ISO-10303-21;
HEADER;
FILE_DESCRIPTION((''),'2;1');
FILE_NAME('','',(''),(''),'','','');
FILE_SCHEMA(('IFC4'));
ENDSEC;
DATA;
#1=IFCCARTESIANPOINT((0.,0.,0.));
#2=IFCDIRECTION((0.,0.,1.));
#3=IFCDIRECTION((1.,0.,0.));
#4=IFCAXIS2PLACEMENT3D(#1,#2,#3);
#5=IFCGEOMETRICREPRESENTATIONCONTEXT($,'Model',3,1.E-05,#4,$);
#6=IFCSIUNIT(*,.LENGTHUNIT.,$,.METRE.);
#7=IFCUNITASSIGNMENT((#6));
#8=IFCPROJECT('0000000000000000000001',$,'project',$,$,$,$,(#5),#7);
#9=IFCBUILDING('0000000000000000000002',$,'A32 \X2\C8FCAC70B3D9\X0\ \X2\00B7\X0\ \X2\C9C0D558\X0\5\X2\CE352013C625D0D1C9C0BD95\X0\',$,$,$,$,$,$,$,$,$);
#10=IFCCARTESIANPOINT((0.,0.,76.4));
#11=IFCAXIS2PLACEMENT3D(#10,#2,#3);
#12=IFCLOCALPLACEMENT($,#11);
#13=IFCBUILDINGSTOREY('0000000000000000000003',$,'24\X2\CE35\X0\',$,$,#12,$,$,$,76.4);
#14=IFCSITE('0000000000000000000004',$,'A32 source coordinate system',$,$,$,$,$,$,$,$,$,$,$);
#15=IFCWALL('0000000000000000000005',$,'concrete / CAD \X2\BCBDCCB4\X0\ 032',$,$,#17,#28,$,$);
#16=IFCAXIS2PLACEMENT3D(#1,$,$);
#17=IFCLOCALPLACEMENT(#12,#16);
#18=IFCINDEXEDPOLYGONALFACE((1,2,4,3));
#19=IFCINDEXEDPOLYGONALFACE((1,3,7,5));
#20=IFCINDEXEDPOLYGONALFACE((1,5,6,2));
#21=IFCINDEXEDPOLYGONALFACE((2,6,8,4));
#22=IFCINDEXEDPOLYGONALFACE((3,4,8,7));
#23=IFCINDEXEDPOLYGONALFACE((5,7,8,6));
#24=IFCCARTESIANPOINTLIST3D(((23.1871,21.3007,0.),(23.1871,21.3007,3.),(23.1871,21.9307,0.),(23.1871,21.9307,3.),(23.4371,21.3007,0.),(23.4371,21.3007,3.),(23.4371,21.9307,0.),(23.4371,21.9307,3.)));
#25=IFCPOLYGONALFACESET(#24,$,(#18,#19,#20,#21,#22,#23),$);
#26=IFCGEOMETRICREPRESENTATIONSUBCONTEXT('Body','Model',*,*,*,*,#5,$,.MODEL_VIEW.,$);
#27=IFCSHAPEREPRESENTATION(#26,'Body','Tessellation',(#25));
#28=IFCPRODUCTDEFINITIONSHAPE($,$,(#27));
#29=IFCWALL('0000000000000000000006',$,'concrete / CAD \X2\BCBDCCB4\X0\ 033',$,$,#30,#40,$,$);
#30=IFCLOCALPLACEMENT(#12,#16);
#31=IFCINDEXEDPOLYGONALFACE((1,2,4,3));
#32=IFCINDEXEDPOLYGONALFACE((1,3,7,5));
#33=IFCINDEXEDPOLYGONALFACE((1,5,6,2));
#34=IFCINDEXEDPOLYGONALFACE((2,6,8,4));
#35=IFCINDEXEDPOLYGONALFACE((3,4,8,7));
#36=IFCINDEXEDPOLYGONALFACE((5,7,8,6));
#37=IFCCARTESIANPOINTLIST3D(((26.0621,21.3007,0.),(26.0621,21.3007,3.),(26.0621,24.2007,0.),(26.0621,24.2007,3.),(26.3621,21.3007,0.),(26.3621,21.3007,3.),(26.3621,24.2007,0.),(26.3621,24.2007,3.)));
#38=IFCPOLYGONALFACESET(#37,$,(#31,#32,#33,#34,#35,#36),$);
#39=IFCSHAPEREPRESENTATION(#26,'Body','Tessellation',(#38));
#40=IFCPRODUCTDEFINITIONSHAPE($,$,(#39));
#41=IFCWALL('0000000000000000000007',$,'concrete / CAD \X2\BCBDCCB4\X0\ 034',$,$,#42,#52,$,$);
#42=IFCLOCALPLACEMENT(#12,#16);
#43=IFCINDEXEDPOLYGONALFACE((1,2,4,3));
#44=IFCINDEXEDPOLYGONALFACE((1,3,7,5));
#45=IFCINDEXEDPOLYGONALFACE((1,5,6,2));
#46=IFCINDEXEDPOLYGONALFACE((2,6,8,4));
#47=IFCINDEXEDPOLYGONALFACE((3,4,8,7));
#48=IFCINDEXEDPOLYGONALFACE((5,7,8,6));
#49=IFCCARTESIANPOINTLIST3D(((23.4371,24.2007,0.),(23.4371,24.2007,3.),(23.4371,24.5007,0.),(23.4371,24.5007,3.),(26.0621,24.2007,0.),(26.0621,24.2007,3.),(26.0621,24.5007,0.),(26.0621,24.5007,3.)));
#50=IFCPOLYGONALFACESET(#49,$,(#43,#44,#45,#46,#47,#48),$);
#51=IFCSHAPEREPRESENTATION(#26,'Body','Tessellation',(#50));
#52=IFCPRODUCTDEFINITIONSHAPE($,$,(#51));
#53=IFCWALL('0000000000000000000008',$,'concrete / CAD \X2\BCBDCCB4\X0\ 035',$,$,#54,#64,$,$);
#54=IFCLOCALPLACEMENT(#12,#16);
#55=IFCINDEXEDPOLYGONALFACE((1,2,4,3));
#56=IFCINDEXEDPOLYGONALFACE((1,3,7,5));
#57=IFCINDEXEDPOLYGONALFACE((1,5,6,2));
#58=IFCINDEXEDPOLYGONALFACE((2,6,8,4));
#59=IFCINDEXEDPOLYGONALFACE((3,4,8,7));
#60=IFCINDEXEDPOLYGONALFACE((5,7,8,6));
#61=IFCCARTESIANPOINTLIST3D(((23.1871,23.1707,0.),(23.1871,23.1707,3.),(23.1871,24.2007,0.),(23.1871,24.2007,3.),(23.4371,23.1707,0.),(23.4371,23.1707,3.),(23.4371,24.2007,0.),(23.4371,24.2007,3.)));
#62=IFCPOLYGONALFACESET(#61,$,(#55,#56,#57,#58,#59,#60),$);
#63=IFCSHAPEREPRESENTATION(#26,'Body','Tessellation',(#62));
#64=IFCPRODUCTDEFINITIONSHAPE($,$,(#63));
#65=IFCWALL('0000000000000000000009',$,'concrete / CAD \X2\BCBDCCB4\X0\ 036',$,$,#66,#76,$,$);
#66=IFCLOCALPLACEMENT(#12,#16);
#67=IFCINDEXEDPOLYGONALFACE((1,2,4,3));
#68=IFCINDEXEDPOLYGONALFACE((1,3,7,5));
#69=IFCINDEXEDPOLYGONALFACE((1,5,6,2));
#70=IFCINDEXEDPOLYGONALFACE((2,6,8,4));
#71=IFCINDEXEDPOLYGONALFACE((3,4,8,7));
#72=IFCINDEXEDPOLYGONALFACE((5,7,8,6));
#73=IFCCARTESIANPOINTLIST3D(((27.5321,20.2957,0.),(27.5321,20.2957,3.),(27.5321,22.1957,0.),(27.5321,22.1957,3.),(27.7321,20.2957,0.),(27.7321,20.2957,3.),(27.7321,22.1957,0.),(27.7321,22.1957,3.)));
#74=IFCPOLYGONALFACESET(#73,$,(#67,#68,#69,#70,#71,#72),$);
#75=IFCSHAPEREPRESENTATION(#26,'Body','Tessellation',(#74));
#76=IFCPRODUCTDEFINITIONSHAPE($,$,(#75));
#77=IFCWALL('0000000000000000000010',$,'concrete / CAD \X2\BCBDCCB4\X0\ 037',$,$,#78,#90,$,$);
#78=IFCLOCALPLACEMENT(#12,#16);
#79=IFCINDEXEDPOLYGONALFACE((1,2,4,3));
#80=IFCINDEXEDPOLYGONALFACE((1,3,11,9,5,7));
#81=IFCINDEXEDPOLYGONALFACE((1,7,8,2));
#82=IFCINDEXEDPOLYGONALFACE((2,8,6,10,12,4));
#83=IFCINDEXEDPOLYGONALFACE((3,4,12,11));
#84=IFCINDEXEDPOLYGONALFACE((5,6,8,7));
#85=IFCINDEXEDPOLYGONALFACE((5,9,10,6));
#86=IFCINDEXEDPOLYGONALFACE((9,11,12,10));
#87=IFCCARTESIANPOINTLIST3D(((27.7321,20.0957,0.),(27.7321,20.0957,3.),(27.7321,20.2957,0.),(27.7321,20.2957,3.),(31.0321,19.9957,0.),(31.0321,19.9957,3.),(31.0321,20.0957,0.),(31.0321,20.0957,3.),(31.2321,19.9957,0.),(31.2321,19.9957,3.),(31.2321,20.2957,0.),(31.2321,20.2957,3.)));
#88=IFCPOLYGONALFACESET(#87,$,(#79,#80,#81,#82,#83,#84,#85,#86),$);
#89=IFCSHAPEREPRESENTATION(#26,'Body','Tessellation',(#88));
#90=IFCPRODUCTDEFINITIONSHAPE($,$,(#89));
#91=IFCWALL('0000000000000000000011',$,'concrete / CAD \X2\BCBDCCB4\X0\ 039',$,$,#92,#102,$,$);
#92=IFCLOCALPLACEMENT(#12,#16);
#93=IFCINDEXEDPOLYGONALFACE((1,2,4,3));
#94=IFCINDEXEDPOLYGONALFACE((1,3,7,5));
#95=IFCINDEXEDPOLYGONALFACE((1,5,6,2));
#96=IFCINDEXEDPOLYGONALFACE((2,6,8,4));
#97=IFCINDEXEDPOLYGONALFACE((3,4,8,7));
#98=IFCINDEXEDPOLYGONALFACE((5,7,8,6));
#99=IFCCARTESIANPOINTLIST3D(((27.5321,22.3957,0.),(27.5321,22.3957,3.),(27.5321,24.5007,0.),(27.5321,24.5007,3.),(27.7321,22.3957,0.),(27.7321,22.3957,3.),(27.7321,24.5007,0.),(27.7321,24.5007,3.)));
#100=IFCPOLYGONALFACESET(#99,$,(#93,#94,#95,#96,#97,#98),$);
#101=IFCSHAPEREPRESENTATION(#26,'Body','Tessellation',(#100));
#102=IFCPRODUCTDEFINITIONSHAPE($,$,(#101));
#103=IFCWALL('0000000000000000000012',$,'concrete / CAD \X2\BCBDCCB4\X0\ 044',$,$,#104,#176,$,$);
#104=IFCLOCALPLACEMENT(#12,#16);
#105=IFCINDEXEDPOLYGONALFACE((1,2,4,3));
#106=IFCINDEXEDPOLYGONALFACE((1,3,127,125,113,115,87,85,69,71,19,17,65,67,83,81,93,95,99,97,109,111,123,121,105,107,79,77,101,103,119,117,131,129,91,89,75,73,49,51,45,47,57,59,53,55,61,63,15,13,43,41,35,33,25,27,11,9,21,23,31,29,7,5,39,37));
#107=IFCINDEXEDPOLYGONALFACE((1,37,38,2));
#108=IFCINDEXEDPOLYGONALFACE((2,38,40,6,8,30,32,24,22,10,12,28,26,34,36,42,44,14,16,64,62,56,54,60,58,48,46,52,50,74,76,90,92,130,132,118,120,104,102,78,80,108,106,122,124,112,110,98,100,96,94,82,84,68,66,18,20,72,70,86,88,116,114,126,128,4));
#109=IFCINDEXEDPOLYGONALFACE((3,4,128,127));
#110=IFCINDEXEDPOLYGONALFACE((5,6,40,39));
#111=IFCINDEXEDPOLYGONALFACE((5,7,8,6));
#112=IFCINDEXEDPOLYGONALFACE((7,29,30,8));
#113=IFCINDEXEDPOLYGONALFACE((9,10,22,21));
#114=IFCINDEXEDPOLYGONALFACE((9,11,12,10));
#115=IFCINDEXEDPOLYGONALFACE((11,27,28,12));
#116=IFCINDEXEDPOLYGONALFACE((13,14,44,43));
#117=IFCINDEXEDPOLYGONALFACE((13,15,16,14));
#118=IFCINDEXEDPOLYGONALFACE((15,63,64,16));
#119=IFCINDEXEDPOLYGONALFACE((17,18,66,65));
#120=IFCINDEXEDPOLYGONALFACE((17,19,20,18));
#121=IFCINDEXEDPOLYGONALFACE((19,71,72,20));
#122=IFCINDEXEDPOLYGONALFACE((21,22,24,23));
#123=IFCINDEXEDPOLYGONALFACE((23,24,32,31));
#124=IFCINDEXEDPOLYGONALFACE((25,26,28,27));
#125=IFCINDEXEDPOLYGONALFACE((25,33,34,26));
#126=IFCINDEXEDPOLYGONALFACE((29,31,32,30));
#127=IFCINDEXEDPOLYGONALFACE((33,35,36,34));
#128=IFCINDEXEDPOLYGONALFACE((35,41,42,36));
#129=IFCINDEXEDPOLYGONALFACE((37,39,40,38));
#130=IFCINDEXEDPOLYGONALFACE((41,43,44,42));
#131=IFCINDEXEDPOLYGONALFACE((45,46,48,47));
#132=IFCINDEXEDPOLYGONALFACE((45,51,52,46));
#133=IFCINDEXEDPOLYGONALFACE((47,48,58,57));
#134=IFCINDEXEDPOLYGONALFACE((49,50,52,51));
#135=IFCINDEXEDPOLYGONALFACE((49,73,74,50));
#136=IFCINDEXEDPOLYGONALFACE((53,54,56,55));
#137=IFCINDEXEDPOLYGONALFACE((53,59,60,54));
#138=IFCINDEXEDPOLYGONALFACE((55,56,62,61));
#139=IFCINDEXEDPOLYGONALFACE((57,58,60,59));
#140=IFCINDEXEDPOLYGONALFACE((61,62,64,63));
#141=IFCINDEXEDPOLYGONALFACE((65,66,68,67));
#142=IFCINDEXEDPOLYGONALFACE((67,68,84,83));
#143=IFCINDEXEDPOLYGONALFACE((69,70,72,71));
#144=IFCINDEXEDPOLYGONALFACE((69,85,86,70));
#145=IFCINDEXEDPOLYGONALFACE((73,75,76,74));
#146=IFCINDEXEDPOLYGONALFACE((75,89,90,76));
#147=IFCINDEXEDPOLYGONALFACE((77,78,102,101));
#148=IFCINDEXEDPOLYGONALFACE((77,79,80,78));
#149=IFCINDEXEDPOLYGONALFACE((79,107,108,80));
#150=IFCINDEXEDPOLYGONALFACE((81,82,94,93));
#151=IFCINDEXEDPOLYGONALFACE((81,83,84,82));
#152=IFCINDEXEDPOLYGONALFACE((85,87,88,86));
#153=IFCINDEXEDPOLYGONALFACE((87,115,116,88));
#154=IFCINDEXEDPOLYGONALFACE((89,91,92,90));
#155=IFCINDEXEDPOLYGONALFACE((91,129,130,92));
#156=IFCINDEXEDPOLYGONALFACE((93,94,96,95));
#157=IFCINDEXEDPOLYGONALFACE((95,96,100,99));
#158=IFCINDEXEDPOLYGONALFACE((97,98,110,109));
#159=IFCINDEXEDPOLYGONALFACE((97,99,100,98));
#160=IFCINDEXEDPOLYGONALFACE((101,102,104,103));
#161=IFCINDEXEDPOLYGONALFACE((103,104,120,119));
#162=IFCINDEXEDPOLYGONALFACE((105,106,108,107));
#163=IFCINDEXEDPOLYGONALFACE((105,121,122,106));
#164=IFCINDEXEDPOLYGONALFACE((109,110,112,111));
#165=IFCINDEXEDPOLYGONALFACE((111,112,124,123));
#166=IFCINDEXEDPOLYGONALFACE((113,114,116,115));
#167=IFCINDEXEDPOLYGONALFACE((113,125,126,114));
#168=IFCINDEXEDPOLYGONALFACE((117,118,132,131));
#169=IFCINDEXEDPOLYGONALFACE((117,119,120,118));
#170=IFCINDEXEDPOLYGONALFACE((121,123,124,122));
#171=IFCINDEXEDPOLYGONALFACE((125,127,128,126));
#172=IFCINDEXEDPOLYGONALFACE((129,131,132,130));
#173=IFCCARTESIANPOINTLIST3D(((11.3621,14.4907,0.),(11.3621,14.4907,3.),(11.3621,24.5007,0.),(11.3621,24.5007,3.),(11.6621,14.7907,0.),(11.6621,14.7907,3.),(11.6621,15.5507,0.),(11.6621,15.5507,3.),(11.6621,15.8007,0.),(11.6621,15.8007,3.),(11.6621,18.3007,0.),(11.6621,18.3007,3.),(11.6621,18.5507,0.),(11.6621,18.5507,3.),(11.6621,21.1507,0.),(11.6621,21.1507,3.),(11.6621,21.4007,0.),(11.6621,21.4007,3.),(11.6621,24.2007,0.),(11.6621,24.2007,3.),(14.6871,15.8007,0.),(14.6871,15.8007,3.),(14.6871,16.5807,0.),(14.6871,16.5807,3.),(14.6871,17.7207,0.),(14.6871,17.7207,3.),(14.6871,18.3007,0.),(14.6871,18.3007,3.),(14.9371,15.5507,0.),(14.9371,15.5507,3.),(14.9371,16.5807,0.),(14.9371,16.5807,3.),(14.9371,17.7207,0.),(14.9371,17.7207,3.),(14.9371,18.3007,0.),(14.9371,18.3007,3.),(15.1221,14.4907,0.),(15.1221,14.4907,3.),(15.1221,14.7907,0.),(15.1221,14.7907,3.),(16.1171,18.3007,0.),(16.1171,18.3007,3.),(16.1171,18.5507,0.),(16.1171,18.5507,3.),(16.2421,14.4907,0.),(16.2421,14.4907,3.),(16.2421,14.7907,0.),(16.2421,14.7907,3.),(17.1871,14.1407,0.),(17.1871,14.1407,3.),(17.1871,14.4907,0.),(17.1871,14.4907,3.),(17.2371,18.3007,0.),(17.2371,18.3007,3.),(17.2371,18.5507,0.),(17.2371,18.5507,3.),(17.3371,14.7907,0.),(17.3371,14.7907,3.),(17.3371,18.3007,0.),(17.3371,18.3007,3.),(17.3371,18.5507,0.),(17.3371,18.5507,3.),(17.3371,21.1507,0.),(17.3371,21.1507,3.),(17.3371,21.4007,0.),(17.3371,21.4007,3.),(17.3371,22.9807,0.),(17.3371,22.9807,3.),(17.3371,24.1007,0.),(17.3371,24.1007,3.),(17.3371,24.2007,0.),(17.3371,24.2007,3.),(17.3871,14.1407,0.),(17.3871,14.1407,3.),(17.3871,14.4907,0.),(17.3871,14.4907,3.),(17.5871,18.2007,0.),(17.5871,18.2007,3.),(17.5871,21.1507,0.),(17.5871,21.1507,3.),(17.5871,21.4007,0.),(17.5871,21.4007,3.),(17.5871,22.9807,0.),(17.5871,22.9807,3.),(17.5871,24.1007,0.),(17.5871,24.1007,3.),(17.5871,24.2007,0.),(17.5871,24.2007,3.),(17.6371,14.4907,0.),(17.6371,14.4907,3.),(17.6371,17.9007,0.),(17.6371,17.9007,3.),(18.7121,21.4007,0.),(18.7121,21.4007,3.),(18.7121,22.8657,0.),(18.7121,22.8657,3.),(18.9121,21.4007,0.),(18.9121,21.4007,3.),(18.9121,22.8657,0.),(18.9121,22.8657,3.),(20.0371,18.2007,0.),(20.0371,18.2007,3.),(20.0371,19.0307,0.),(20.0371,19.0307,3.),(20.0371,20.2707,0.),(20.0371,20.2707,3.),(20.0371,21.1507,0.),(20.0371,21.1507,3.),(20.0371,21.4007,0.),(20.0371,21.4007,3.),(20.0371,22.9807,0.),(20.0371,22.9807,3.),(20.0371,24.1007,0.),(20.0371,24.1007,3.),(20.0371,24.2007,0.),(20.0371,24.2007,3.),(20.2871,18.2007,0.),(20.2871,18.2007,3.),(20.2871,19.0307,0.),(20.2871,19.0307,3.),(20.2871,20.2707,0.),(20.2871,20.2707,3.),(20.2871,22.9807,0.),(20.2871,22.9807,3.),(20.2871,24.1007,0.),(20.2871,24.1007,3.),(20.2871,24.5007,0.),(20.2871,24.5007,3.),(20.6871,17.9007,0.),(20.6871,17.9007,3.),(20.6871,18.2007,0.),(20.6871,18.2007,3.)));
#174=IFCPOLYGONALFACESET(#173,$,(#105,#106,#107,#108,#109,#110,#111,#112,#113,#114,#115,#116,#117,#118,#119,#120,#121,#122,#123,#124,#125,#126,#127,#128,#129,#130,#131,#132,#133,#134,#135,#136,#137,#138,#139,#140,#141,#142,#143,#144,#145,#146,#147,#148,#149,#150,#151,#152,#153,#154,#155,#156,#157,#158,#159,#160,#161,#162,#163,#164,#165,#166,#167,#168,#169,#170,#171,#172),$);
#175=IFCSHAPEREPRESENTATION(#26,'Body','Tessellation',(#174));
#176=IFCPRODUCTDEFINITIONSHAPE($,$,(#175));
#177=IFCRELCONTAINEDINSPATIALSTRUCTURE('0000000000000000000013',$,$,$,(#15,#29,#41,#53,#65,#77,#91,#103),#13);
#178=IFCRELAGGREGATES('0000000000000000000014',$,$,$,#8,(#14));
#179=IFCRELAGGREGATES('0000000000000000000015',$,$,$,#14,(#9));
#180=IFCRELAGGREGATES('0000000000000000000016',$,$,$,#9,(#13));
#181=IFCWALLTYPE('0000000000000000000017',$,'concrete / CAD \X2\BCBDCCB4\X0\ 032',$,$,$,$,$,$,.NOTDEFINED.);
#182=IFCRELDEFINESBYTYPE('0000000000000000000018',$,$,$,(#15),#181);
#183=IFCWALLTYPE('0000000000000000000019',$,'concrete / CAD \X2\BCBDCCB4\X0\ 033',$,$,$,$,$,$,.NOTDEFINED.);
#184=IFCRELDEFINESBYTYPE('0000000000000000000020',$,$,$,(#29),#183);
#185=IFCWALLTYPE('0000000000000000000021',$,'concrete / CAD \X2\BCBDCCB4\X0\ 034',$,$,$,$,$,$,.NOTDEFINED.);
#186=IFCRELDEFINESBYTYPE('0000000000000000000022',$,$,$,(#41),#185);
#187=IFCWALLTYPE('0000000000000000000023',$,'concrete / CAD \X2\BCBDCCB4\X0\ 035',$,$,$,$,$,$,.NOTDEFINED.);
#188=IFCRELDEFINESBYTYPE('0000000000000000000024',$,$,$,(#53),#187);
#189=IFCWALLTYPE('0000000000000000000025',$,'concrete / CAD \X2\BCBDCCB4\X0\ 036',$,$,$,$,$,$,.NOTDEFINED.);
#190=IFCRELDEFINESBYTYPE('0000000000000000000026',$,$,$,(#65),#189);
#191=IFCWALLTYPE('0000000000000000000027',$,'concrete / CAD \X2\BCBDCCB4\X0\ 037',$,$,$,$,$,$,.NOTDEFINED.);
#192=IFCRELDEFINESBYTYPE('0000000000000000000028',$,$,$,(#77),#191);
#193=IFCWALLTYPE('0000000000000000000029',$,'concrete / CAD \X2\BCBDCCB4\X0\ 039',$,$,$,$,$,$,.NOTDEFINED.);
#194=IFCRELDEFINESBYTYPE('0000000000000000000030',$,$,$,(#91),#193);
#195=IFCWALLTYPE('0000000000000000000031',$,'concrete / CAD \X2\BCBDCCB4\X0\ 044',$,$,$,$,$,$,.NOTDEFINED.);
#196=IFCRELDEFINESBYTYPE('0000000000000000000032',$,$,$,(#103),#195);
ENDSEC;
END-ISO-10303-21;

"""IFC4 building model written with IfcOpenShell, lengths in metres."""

from ifc_helpers import new_model, si_unit, frame, origin, origin_with_axes, place, context, subcontext, project, spatial, polyline, outline, extrude, source, transform, mapped, type_object, type_shapes, element, save


model = new_model("IFC4")

# Units and contexts
model_context = context("Model", 3, precision=1e-05, world=origin_with_axes())
body_context = subcontext(model_context, "Body", "Model", "MODEL_VIEW")
ifc_project = project(units=[si_unit("LENGTHUNIT", "METRE")], contexts=[model_context])

# Site, building, storey
site = spatial("IfcSite", under=ifc_project, Name="A32 source coordinate system")
building = spatial("IfcBuilding", under=site, Name="A32 주거동 · 지하5층–옥탑지붕")
storey_placement = place(None, frame((0.0, 0.0, 76.4), z_axis=(0.0, 0.0, 1.0), x_axis=(1.0, 0.0, 0.0)))
storey = spatial("IfcBuildingStorey", under=building, at=storey_placement, Name="24층", Elevation=76.4)

# Walls
wall_type_1 = type_object("IfcWallType", Name="concrete / CAD 벽체 032", PredefinedType="NOTDEFINED")
shared_shape_1 = source(origin(), body_context, "Body", "SweptSolid", [
    extrude(outline(polyline([(23.4371, 21.3007), (23.1871, 21.3007), (23.1871, 21.9307), (23.4371, 21.9307), (23.4371, 21.3007)])), origin(), (0.0, 0.0, 1.0), 3.0),
])
type_shapes(wall_type_1, [shared_shape_1])
wall_1_placement = place(storey_placement, origin_with_axes())
element("IfcWall", 1, at=wall_1_placement, inside=storey, type_object=wall_type_1, Name="concrete / CAD 벽체 032", context=body_context, shape_type="MappedRepresentation", body=[
    mapped(shared_shape_1, transform((0.0, 0.0, 0.0), scale=1.0)),
])
wall_type_2 = type_object("IfcWallType", Name="concrete / CAD 벽체 033", PredefinedType="NOTDEFINED")
shared_shape_2 = source(origin(), body_context, "Body", "SweptSolid", [
    extrude(outline(polyline([(26.3621, 21.3007), (26.0621, 21.3007), (26.0621, 24.2007), (26.3621, 24.2007), (26.3621, 21.3007)])), origin(), (0.0, 0.0, 1.0), 3.0),
])
type_shapes(wall_type_2, [shared_shape_2])
wall_2_placement = place(storey_placement, origin_with_axes())
element("IfcWall", 2, at=wall_2_placement, inside=storey, type_object=wall_type_2, Name="concrete / CAD 벽체 033", context=body_context, shape_type="MappedRepresentation", body=[
    mapped(shared_shape_2, transform((0.0, 0.0, 0.0), scale=1.0)),
])
wall_type_3 = type_object("IfcWallType", Name="concrete / CAD 벽체 034", PredefinedType="NOTDEFINED")
shared_shape_3 = source(origin(), body_context, "Body", "SweptSolid", [
    extrude(outline(polyline([(26.0621, 24.5007), (26.0621, 24.2007), (23.4371, 24.2007), (23.4371, 24.5007), (26.0621, 24.5007)])), origin(), (0.0, 0.0, 1.0), 3.0),
])
type_shapes(wall_type_3, [shared_shape_3])
wall_3_placement = place(storey_placement, origin_with_axes())
element("IfcWall", 3, at=wall_3_placement, inside=storey, type_object=wall_type_3, Name="concrete / CAD 벽체 034", context=body_context, shape_type="MappedRepresentation", body=[
    mapped(shared_shape_3, transform((0.0, 0.0, 0.0), scale=1.0)),
])
wall_type_4 = type_object("IfcWallType", Name="concrete / CAD 벽체 035", PredefinedType="NOTDEFINED")
shared_shape_4 = source(origin(), body_context, "Body", "SweptSolid", [
    extrude(outline(polyline([(23.1871, 24.2007), (23.4371, 24.2007), (23.4371, 23.1707), (23.1871, 23.1707), (23.1871, 24.2007)])), origin(), (0.0, 0.0, 1.0), 3.0),
])
type_shapes(wall_type_4, [shared_shape_4])
wall_4_placement = place(storey_placement, origin_with_axes())
element("IfcWall", 4, at=wall_4_placement, inside=storey, type_object=wall_type_4, Name="concrete / CAD 벽체 035", context=body_context, shape_type="MappedRepresentation", body=[
    mapped(shared_shape_4, transform((0.0, 0.0, 0.0), scale=1.0)),
])
wall_type_5 = type_object("IfcWallType", Name="concrete / CAD 벽체 036", PredefinedType="NOTDEFINED")
shared_shape_5 = source(origin(), body_context, "Body", "SweptSolid", [
    extrude(outline(polyline([(27.7321, 20.2957), (27.5321, 20.2957), (27.5321, 22.1957), (27.7321, 22.1957), (27.7321, 20.2957)])), origin(), (0.0, 0.0, 1.0), 3.0),
])
type_shapes(wall_type_5, [shared_shape_5])
wall_5_placement = place(storey_placement, origin_with_axes())
element("IfcWall", 5, at=wall_5_placement, inside=storey, type_object=wall_type_5, Name="concrete / CAD 벽체 036", context=body_context, shape_type="MappedRepresentation", body=[
    mapped(shared_shape_5, transform((0.0, 0.0, 0.0), scale=1.0)),
])
wall_type_6 = type_object("IfcWallType", Name="concrete / CAD 벽체 037", PredefinedType="NOTDEFINED")
shared_shape_6 = source(origin(), body_context, "Body", "SweptSolid", [
    extrude(outline(polyline([(31.0321, 19.9957), (31.0321, 20.0957), (27.7321, 20.0957), (27.7321, 20.2957), (31.2321, 20.2957), (31.2321, 19.9957), (31.0321, 19.9957)])), origin(), (0.0, 0.0, 1.0), 3.0),
])
type_shapes(wall_type_6, [shared_shape_6])
wall_6_placement = place(storey_placement, origin_with_axes())
element("IfcWall", 6, at=wall_6_placement, inside=storey, type_object=wall_type_6, Name="concrete / CAD 벽체 037", context=body_context, shape_type="MappedRepresentation", body=[
    mapped(shared_shape_6, transform((0.0, 0.0, 0.0), scale=1.0)),
])
wall_type_7 = type_object("IfcWallType", Name="concrete / CAD 벽체 039", PredefinedType="NOTDEFINED")
shared_shape_7 = source(origin(), body_context, "Body", "SweptSolid", [
    extrude(outline(polyline([(27.7321, 22.3957), (27.5321, 22.3957), (27.5321, 24.5007), (27.7321, 24.5007), (27.7321, 22.3957)])), origin(), (0.0, 0.0, 1.0), 3.0),
])
type_shapes(wall_type_7, [shared_shape_7])
wall_7_placement = place(storey_placement, origin_with_axes())
element("IfcWall", 7, at=wall_7_placement, inside=storey, type_object=wall_type_7, Name="concrete / CAD 벽체 039", context=body_context, shape_type="MappedRepresentation", body=[
    mapped(shared_shape_7, transform((0.0, 0.0, 0.0), scale=1.0)),
])
wall_type_8 = type_object("IfcWallType", Name="concrete / CAD 벽체 044", PredefinedType="NOTDEFINED")
shared_shape_8 = source(origin(), body_context, "Body", "SweptSolid", [
    extrude(outline(polyline([(17.3371, 22.9807), (17.5871, 22.9807), (17.5871, 21.4007), (18.7121, 21.4007), (18.7121, 22.8657), (18.9121, 22.8657), (18.9121, 21.4007), (20.0371, 21.4007), (20.0371, 22.9807), (20.2871, 22.9807), (20.2871, 20.2707), (20.0371, 20.2707), (20.0371, 21.1507), (17.5871, 21.1507), (17.5871, 18.2007), (20.0371, 18.2007), (20.0371, 19.0307), (20.2871, 19.0307), (20.2871, 18.2007), (20.6871, 18.2007), (20.6871, 17.9007), (17.6371, 17.9007), (17.6371, 14.4907), (17.3871, 14.4907), (17.3871, 14.1407), (17.1871, 14.1407), (17.1871, 14.4907), (16.2421, 14.4907), (16.2421, 14.7907), (17.3371, 14.7907), (17.3371, 18.3007), (17.2371, 18.3007), (17.2371, 18.5507), (17.3371, 18.5507), (17.3371, 21.1507), (11.6621, 21.1507), (11.6621, 18.5507), (16.1171, 18.5507), (16.1171, 18.3007), (14.9371, 18.3007), (14.9371, 17.7207), (14.6871, 17.7207), (14.6871, 18.3007), (11.6621, 18.3007), (11.6621, 15.8007), (14.6871, 15.8007), (14.6871, 16.5807), (14.9371, 16.5807), (14.9371, 15.5507), (11.6621, 15.5507), (11.6621, 14.7907), (15.1221, 14.7907), (15.1221, 14.4907), (11.3621, 14.4907), (11.3621, 24.5007), (20.2871, 24.5007), (20.2871, 24.1007), (20.0371, 24.1007), (20.0371, 24.2007), (17.5871, 24.2007), (17.5871, 24.1007), (17.3371, 24.1007), (17.3371, 24.2007), (11.6621, 24.2007), (11.6621, 21.4007), (17.3371, 21.4007), (17.3371, 22.9807)])), origin(), (0.0, 0.0, 1.0), 3.0),
])
type_shapes(wall_type_8, [shared_shape_8])
wall_8_placement = place(storey_placement, origin_with_axes())
element("IfcWall", 8, at=wall_8_placement, inside=storey, type_object=wall_type_8, Name="concrete / CAD 벽체 044", context=body_context, shape_type="MappedRepresentation", body=[
    mapped(shared_shape_8, transform((0.0, 0.0, 0.0), scale=1.0)),
])

save(model, "model.ifc")
